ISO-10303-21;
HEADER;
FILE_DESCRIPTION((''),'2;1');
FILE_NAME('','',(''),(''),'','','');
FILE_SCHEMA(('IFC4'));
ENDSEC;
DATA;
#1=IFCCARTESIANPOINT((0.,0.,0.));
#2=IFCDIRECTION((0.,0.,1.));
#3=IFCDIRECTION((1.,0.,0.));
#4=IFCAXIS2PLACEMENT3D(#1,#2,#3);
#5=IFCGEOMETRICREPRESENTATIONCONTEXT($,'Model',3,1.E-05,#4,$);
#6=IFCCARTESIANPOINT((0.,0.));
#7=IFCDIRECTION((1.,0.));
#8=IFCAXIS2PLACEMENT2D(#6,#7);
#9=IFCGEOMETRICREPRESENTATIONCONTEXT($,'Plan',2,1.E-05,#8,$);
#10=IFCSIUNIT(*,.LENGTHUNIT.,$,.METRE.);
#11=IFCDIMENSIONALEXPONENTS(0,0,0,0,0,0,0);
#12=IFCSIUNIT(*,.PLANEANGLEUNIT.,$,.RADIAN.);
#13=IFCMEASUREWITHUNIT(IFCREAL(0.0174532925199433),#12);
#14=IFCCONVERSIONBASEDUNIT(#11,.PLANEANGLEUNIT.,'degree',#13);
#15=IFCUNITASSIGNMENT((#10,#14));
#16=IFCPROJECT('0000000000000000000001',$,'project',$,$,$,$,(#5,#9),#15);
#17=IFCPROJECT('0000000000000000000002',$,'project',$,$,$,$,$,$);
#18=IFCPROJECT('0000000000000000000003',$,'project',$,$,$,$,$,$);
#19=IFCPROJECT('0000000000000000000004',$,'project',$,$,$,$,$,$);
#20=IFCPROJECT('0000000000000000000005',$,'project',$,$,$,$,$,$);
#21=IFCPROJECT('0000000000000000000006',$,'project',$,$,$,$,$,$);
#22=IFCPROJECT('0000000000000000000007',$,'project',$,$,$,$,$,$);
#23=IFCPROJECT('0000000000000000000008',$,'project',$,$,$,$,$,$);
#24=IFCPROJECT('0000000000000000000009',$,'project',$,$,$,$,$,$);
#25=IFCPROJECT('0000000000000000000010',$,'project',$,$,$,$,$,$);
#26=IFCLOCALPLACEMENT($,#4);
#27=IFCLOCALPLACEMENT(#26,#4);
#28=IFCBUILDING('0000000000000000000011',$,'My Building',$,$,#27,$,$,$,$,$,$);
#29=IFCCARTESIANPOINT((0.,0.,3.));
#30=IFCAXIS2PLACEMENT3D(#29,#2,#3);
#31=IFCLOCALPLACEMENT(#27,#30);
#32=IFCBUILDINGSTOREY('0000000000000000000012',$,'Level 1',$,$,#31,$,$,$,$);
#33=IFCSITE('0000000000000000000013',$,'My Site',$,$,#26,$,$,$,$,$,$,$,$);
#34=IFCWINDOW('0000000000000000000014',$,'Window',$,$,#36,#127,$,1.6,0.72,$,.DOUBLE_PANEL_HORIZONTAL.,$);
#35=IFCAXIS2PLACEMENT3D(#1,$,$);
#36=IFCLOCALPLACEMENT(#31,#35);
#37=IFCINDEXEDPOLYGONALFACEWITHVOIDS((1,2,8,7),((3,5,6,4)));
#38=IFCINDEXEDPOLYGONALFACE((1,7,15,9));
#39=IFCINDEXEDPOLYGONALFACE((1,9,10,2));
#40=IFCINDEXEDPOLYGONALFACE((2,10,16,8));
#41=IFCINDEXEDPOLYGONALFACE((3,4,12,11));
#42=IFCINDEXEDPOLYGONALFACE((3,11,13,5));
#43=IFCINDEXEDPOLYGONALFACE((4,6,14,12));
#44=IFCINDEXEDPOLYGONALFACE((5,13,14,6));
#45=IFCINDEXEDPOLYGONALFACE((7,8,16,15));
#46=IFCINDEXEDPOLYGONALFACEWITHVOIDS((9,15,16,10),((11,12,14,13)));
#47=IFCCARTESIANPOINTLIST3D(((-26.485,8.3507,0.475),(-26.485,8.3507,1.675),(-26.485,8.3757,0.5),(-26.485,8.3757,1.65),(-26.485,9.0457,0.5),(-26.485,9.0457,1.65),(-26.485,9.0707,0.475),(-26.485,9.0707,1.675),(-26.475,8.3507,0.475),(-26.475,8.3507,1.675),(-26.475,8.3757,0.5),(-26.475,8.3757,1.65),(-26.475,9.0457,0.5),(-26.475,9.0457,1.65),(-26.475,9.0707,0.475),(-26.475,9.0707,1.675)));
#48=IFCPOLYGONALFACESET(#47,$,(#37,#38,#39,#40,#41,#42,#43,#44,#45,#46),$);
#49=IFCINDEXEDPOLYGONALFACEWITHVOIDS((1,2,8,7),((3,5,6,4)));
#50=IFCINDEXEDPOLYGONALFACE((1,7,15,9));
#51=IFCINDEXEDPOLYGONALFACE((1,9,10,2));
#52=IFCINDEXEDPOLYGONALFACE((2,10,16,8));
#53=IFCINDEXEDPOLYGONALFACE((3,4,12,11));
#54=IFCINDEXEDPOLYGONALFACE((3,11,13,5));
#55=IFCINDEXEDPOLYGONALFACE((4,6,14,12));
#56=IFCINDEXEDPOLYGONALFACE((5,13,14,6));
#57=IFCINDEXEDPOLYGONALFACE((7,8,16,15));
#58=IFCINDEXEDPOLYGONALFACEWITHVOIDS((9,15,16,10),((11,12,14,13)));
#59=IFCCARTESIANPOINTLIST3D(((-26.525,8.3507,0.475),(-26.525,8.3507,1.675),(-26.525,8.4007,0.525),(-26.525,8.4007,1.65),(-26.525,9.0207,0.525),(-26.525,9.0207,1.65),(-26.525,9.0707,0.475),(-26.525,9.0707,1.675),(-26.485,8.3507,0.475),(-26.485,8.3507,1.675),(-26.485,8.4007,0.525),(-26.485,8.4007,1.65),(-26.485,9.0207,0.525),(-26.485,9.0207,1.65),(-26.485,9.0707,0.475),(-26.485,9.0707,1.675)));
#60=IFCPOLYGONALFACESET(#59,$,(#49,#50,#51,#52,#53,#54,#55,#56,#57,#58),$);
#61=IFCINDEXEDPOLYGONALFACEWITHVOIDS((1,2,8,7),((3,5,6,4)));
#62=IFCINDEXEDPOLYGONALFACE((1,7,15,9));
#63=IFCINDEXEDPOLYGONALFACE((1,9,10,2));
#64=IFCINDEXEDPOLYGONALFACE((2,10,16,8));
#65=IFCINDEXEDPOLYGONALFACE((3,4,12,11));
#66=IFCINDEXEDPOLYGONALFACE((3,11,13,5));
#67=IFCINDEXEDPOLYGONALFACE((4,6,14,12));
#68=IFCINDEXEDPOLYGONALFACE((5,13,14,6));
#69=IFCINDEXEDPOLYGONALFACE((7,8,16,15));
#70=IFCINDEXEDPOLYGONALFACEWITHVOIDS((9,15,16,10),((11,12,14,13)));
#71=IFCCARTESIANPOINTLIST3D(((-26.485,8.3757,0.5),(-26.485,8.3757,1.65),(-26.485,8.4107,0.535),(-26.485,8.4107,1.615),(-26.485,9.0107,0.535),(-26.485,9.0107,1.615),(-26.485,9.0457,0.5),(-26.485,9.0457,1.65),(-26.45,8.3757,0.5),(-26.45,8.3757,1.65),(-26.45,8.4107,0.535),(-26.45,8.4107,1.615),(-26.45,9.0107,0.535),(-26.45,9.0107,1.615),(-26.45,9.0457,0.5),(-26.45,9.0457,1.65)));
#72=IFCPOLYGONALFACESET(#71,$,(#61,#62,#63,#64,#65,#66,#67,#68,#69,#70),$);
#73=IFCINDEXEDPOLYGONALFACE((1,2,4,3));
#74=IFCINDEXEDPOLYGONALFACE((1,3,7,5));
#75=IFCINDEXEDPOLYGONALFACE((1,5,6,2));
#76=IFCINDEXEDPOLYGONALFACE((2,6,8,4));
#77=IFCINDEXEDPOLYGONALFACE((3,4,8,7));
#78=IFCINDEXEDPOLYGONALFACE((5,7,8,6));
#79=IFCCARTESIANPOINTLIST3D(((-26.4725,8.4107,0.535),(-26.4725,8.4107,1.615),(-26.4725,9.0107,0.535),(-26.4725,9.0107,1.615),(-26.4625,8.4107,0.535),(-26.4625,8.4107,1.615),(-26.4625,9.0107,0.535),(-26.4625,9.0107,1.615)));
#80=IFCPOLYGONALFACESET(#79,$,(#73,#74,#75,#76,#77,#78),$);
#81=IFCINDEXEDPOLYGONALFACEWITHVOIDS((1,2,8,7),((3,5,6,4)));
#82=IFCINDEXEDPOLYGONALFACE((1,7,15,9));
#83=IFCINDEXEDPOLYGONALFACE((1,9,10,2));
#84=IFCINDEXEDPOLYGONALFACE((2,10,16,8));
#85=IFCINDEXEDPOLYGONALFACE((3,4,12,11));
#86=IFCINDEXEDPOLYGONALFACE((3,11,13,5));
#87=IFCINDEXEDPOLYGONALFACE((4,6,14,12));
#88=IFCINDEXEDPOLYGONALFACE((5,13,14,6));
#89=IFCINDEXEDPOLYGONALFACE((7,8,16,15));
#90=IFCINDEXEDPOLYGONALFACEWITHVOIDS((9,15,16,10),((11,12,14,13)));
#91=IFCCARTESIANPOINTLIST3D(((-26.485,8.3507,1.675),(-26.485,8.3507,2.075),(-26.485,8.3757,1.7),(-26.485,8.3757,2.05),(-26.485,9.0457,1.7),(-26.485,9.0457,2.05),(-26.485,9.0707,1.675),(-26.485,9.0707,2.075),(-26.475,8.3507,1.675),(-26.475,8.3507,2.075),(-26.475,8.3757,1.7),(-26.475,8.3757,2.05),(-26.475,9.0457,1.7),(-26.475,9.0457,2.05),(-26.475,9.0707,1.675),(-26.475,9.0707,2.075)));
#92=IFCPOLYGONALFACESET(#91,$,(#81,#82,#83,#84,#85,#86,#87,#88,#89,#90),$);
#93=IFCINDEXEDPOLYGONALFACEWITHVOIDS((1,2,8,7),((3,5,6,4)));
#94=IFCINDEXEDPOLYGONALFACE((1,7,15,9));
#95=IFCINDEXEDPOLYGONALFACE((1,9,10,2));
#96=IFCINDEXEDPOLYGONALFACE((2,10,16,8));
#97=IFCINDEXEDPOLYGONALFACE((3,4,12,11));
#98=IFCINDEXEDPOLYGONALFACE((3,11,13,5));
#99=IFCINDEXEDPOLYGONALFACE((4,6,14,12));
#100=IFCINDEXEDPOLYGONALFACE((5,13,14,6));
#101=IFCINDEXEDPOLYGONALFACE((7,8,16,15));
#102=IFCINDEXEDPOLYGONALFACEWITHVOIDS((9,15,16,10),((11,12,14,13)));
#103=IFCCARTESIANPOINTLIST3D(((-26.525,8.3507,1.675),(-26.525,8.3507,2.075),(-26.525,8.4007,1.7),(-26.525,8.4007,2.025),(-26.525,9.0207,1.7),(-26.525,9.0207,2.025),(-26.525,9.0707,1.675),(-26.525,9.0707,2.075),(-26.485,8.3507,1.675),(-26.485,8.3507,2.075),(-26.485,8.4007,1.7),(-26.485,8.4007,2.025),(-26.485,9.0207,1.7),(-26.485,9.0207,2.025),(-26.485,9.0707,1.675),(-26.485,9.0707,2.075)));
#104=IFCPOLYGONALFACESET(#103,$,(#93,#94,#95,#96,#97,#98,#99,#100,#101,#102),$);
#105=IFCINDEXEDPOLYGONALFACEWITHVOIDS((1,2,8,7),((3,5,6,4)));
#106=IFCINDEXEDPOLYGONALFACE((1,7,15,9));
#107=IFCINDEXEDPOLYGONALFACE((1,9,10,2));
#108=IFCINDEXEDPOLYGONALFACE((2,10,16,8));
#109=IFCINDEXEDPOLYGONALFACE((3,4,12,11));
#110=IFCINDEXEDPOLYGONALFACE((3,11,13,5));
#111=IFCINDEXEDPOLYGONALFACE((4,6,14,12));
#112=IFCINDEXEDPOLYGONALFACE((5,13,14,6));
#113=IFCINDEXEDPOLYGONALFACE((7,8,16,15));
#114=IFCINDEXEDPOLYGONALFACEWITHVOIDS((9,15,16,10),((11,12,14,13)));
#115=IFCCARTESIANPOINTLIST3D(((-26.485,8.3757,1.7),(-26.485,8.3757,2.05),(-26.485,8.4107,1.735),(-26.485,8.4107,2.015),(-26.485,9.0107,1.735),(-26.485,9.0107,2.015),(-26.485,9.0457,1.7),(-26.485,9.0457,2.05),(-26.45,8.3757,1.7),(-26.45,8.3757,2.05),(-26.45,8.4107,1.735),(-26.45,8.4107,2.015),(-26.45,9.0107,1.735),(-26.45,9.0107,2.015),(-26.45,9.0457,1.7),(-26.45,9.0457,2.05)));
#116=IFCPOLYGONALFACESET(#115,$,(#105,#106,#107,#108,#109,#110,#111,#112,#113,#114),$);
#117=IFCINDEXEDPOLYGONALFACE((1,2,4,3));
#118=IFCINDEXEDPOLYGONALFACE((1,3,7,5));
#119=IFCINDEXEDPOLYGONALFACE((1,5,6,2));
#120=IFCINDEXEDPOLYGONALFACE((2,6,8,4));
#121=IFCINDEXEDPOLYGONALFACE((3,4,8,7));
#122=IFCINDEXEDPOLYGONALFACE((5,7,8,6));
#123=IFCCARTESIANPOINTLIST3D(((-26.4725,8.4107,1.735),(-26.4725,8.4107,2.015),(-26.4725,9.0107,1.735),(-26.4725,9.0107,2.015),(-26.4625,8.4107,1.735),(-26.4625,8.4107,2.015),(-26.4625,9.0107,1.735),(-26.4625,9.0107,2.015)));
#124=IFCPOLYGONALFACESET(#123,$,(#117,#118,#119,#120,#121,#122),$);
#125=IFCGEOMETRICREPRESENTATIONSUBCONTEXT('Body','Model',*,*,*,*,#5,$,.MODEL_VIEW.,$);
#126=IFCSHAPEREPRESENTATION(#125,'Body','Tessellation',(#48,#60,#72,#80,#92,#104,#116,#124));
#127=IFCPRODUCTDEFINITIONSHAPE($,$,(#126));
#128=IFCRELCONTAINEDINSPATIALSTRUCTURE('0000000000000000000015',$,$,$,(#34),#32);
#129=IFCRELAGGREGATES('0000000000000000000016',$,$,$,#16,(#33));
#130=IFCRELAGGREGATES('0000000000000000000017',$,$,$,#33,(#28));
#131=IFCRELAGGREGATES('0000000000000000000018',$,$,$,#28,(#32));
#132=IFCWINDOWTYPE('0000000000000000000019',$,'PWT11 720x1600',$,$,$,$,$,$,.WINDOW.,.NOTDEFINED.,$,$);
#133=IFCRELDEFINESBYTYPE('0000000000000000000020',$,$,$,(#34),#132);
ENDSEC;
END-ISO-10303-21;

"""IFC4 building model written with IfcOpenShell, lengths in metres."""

from ifc_helpers import new_model, entity, si_unit, converted_unit, frame, origin_with_axes, origin_2d_with_axis, place, context, subcontext, project, spatial, line, indexed_curve, outline, extrude, shape, source, transform, mapped, type_object, type_shapes, element, save


model = new_model("IFC4")

# Units and contexts
model_context = context("Model", 3, precision=1e-05, world=origin_with_axes())
plan_context = context("Plan", 2, precision=1e-05, world=origin_2d_with_axis())
body_context_1 = subcontext(model_context, "Body", "Model", "MODEL_VIEW")
body_context_2 = subcontext(plan_context, "Body", "Plan", "PLAN_VIEW")
ifc_project_1 = project(units=[si_unit("LENGTHUNIT", "METRE"), converted_unit("PLANEANGLEUNIT", "degree", entity("IfcReal", 0.0174532925199433), si_unit("PLANEANGLEUNIT", "RADIAN"), dimensions=[0, 0, 0, 0, 0, 0, 0])], contexts=[model_context, plan_context])
ifc_project_2 = project()
ifc_project_3 = project()
ifc_project_4 = project()
ifc_project_5 = project()
ifc_project_6 = project()
ifc_project_7 = project()
ifc_project_8 = project()
ifc_project_9 = project()
ifc_project_10 = project()

# Site, building, storey
site_placement = place(None, origin_with_axes())
site = spatial("IfcSite", under=ifc_project_1, at=site_placement, Name="My Site")
building_placement = place(site_placement, origin_with_axes())
building = spatial("IfcBuilding", under=site, at=building_placement, Name="My Building")
storey_placement = place(building_placement, frame((0.0, 0.0, 3.0), z_axis=(0.0, 0.0, 1.0), x_axis=(1.0, 0.0, 0.0)))
storey = spatial("IfcBuildingStorey", under=building, at=storey_placement, Name="Level 1")

# Window
window_type_1 = type_object("IfcWindowType", Name="PWT11 720x1600", PartitioningType="NOTDEFINED", PredefinedType="WINDOW")
shared_shape_1 = source(origin_with_axes(), body_context_1, "Body", "SweptSolid", [
    extrude(outline(indexed_curve([(0.0, 0.0), (0.72, 0.0), (0.72, 1.2), (0.0, 1.2)], segments=[line(1, 2, 2, 3, 3, 4, 4, 1)]), holes=[indexed_curve([(0.025, 0.025), (0.695, 0.025), (0.695, 1.175), (0.025, 1.175)], segments=[line(1, 2, 2, 3, 3, 4, 4, 1)])]), frame((0.0, 0.04, 0.0), z_axis=(0.0, -1.0, 0.0), x_axis=(1.0, 0.0, 0.0)), (0.0, 0.0, -1.0), 0.01),
    extrude(outline(indexed_curve([(0.0, 0.0), (0.72, 0.0), (0.72, 1.2), (0.0, 1.2)], segments=[line(1, 2, 2, 3, 3, 4, 4, 1)]), holes=[indexed_curve([(0.05, 0.05), (0.67, 0.05), (0.67, 1.175), (0.05, 1.175)], segments=[line(1, 2, 2, 3, 3, 4, 4, 1)])]), frame((0.0, 0.0, 0.0), z_axis=(0.0, -1.0, 0.0), x_axis=(1.0, 0.0, 0.0)), (0.0, 0.0, -1.0), 0.04),
    extrude(outline(indexed_curve([(0.0, 0.0), (0.67, 0.0), (0.67, 1.15), (0.0, 1.15)], segments=[line(1, 2, 2, 3, 3, 4, 4, 1)]), holes=[indexed_curve([(0.035, 0.035), (0.635, 0.035), (0.635, 1.115), (0.035, 1.115)], segments=[line(1, 2, 2, 3, 3, 4, 4, 1)])]), frame((0.025, 0.04, 0.025), z_axis=(0.0, -1.0, 0.0), x_axis=(1.0, 0.0, 0.0)), (0.0, 0.0, -1.0), 0.035),
    extrude(outline(indexed_curve([(0.035, 0.035), (0.635, 0.035), (0.635, 1.115), (0.035, 1.115)], segments=[line(1, 2, 2, 3, 3, 4, 4, 1)])), frame((0.025, 0.0525, 0.025), z_axis=(0.0, -1.0, 0.0), x_axis=(1.0, 0.0, 0.0)), (0.0, 0.0, -1.0), 0.01),
    extrude(outline(indexed_curve([(0.0, 0.0), (0.72, 0.0), (0.72, 0.4), (0.0, 0.4)], segments=[line(1, 2, 2, 3, 3, 4, 4, 1)]), holes=[indexed_curve([(0.025, 0.025), (0.695, 0.025), (0.695, 0.375), (0.025, 0.375)], segments=[line(1, 2, 2, 3, 3, 4, 4, 1)])]), frame((0.0, 0.04, 1.2), z_axis=(0.0, -1.0, 0.0), x_axis=(1.0, 0.0, 0.0)), (0.0, 0.0, -1.0), 0.01),
    extrude(outline(indexed_curve([(0.0, 0.0), (0.72, 0.0), (0.72, 0.4), (0.0, 0.4)], segments=[line(1, 2, 2, 3, 3, 4, 4, 1)]), holes=[indexed_curve([(0.05, 0.025), (0.67, 0.025), (0.67, 0.35), (0.05, 0.35)], segments=[line(1, 2, 2, 3, 3, 4, 4, 1)])]), frame((0.0, 0.0, 1.2), z_axis=(0.0, -1.0, 0.0), x_axis=(1.0, 0.0, 0.0)), (0.0, 0.0, -1.0), 0.04),
    extrude(outline(indexed_curve([(0.0, 0.0), (0.67, 0.0), (0.67, 0.35), (0.0, 0.35)], segments=[line(1, 2, 2, 3, 3, 4, 4, 1)]), holes=[indexed_curve([(0.035, 0.035), (0.635, 0.035), (0.635, 0.315), (0.035, 0.315)], segments=[line(1, 2, 2, 3, 3, 4, 4, 1)])]), frame((0.025, 0.04, 1.225), z_axis=(0.0, -1.0, 0.0), x_axis=(1.0, 0.0, 0.0)), (0.0, 0.0, -1.0), 0.035),
    extrude(outline(indexed_curve([(0.035, 0.035), (0.635, 0.035), (0.635, 0.315), (0.035, 0.315)], segments=[line(1, 2, 2, 3, 3, 4, 4, 1)])), frame((0.025, 0.0525, 1.225), z_axis=(0.0, -1.0, 0.0), x_axis=(1.0, 0.0, 0.0)), (0.0, 0.0, -1.0), 0.01),
])
shared_shape_2 = source(origin_with_axes(), body_context_2, "Body", "Curve2D", [
    entity("IfcIndexedPolyCurve", entity("IfcCartesianPointList2D", [[0.05, 0.0], [0.67, 0.0]]), [entity("IfcLineIndex", [1, 2])]),
    entity("IfcIndexedPolyCurve", entity("IfcCartesianPointList2D", [[0.0, 0.05], [0.025, 0.05], [0.025, 0.04], [0.05, 0.04], [0.05, 0.0], [0.0, 0.0]]), [entity("IfcLineIndex", [1, 2, 2, 3, 3, 4, 4, 5, 5, 6, 6, 1])]),
    entity("IfcIndexedPolyCurve", entity("IfcCartesianPointList2D", [[0.72, 0.05], [0.695, 0.05], [0.695, 0.04], [0.67, 0.04], [0.67, 0.0], [0.72, 0.0]]), [entity("IfcLineIndex", [1, 2, 2, 3, 3, 4, 4, 5, 5, 6, 6, 1])]),
    entity("IfcIndexedPolyCurve", entity("IfcCartesianPointList2D", [[0.025, 0.04], [0.06, 0.04], [0.06, 0.075], [0.025, 0.075]]), [entity("IfcLineIndex", [1, 2, 2, 3, 3, 4, 4, 1])]),
    entity("IfcIndexedPolyCurve", entity("IfcCartesianPointList2D", [[0.695, 0.04], [0.66, 0.04], [0.66, 0.075], [0.695, 0.075]]), [entity("IfcLineIndex", [1, 2, 2, 3, 3, 4, 4, 1])]),
    entity("IfcIndexedPolyCurve", entity("IfcCartesianPointList2D", [[0.06, 0.04], [0.66, 0.04]]), [entity("IfcLineIndex", [1, 2])]),
    entity("IfcIndexedPolyCurve", entity("IfcCartesianPointList2D", [[0.06, 0.075], [0.66, 0.075]]), [entity("IfcLineIndex", [1, 2])]),
    entity("IfcIndexedPolyCurve", entity("IfcCartesianPointList2D", [[0.06, 0.0575], [0.66, 0.0575]]), [entity("IfcLineIndex", [1, 2])]),
])
type_shapes(window_type_1, [shared_shape_1, shared_shape_2])
window_1_placement = place(storey_placement, frame((-26.525, 9.0707, 0.475), z_axis=(0.0, 0.0, 1.0), x_axis=(-0.000001, -1.0, 0.0)))
element("IfcWindow", 1, at=window_1_placement, inside=storey, type_object=window_type_1, Name="Window", OverallHeight=1.6, OverallWidth=0.72, PartitioningType="DOUBLE_PANEL_HORIZONTAL", shapes=[
    shape(body_context_1, "Body", "MappedRepresentation", [mapped(shared_shape_1, transform((0.0, 0.0, 0.0), x_axis=(1.0, 0.0, 0.0), y_axis=(0.0, 1.0, 0.0), z_axis=(0.0, 0.0, 1.0), scale=1.0))]),
    shape(body_context_2, "Body", "MappedRepresentation", [mapped(shared_shape_2, transform((0.0, 0.0, 0.0), x_axis=(1.0, 0.0, 0.0), y_axis=(0.0, 1.0, 0.0), z_axis=(0.0, 0.0, 1.0), scale=1.0))]),
])

save(model, "model.ifc")
